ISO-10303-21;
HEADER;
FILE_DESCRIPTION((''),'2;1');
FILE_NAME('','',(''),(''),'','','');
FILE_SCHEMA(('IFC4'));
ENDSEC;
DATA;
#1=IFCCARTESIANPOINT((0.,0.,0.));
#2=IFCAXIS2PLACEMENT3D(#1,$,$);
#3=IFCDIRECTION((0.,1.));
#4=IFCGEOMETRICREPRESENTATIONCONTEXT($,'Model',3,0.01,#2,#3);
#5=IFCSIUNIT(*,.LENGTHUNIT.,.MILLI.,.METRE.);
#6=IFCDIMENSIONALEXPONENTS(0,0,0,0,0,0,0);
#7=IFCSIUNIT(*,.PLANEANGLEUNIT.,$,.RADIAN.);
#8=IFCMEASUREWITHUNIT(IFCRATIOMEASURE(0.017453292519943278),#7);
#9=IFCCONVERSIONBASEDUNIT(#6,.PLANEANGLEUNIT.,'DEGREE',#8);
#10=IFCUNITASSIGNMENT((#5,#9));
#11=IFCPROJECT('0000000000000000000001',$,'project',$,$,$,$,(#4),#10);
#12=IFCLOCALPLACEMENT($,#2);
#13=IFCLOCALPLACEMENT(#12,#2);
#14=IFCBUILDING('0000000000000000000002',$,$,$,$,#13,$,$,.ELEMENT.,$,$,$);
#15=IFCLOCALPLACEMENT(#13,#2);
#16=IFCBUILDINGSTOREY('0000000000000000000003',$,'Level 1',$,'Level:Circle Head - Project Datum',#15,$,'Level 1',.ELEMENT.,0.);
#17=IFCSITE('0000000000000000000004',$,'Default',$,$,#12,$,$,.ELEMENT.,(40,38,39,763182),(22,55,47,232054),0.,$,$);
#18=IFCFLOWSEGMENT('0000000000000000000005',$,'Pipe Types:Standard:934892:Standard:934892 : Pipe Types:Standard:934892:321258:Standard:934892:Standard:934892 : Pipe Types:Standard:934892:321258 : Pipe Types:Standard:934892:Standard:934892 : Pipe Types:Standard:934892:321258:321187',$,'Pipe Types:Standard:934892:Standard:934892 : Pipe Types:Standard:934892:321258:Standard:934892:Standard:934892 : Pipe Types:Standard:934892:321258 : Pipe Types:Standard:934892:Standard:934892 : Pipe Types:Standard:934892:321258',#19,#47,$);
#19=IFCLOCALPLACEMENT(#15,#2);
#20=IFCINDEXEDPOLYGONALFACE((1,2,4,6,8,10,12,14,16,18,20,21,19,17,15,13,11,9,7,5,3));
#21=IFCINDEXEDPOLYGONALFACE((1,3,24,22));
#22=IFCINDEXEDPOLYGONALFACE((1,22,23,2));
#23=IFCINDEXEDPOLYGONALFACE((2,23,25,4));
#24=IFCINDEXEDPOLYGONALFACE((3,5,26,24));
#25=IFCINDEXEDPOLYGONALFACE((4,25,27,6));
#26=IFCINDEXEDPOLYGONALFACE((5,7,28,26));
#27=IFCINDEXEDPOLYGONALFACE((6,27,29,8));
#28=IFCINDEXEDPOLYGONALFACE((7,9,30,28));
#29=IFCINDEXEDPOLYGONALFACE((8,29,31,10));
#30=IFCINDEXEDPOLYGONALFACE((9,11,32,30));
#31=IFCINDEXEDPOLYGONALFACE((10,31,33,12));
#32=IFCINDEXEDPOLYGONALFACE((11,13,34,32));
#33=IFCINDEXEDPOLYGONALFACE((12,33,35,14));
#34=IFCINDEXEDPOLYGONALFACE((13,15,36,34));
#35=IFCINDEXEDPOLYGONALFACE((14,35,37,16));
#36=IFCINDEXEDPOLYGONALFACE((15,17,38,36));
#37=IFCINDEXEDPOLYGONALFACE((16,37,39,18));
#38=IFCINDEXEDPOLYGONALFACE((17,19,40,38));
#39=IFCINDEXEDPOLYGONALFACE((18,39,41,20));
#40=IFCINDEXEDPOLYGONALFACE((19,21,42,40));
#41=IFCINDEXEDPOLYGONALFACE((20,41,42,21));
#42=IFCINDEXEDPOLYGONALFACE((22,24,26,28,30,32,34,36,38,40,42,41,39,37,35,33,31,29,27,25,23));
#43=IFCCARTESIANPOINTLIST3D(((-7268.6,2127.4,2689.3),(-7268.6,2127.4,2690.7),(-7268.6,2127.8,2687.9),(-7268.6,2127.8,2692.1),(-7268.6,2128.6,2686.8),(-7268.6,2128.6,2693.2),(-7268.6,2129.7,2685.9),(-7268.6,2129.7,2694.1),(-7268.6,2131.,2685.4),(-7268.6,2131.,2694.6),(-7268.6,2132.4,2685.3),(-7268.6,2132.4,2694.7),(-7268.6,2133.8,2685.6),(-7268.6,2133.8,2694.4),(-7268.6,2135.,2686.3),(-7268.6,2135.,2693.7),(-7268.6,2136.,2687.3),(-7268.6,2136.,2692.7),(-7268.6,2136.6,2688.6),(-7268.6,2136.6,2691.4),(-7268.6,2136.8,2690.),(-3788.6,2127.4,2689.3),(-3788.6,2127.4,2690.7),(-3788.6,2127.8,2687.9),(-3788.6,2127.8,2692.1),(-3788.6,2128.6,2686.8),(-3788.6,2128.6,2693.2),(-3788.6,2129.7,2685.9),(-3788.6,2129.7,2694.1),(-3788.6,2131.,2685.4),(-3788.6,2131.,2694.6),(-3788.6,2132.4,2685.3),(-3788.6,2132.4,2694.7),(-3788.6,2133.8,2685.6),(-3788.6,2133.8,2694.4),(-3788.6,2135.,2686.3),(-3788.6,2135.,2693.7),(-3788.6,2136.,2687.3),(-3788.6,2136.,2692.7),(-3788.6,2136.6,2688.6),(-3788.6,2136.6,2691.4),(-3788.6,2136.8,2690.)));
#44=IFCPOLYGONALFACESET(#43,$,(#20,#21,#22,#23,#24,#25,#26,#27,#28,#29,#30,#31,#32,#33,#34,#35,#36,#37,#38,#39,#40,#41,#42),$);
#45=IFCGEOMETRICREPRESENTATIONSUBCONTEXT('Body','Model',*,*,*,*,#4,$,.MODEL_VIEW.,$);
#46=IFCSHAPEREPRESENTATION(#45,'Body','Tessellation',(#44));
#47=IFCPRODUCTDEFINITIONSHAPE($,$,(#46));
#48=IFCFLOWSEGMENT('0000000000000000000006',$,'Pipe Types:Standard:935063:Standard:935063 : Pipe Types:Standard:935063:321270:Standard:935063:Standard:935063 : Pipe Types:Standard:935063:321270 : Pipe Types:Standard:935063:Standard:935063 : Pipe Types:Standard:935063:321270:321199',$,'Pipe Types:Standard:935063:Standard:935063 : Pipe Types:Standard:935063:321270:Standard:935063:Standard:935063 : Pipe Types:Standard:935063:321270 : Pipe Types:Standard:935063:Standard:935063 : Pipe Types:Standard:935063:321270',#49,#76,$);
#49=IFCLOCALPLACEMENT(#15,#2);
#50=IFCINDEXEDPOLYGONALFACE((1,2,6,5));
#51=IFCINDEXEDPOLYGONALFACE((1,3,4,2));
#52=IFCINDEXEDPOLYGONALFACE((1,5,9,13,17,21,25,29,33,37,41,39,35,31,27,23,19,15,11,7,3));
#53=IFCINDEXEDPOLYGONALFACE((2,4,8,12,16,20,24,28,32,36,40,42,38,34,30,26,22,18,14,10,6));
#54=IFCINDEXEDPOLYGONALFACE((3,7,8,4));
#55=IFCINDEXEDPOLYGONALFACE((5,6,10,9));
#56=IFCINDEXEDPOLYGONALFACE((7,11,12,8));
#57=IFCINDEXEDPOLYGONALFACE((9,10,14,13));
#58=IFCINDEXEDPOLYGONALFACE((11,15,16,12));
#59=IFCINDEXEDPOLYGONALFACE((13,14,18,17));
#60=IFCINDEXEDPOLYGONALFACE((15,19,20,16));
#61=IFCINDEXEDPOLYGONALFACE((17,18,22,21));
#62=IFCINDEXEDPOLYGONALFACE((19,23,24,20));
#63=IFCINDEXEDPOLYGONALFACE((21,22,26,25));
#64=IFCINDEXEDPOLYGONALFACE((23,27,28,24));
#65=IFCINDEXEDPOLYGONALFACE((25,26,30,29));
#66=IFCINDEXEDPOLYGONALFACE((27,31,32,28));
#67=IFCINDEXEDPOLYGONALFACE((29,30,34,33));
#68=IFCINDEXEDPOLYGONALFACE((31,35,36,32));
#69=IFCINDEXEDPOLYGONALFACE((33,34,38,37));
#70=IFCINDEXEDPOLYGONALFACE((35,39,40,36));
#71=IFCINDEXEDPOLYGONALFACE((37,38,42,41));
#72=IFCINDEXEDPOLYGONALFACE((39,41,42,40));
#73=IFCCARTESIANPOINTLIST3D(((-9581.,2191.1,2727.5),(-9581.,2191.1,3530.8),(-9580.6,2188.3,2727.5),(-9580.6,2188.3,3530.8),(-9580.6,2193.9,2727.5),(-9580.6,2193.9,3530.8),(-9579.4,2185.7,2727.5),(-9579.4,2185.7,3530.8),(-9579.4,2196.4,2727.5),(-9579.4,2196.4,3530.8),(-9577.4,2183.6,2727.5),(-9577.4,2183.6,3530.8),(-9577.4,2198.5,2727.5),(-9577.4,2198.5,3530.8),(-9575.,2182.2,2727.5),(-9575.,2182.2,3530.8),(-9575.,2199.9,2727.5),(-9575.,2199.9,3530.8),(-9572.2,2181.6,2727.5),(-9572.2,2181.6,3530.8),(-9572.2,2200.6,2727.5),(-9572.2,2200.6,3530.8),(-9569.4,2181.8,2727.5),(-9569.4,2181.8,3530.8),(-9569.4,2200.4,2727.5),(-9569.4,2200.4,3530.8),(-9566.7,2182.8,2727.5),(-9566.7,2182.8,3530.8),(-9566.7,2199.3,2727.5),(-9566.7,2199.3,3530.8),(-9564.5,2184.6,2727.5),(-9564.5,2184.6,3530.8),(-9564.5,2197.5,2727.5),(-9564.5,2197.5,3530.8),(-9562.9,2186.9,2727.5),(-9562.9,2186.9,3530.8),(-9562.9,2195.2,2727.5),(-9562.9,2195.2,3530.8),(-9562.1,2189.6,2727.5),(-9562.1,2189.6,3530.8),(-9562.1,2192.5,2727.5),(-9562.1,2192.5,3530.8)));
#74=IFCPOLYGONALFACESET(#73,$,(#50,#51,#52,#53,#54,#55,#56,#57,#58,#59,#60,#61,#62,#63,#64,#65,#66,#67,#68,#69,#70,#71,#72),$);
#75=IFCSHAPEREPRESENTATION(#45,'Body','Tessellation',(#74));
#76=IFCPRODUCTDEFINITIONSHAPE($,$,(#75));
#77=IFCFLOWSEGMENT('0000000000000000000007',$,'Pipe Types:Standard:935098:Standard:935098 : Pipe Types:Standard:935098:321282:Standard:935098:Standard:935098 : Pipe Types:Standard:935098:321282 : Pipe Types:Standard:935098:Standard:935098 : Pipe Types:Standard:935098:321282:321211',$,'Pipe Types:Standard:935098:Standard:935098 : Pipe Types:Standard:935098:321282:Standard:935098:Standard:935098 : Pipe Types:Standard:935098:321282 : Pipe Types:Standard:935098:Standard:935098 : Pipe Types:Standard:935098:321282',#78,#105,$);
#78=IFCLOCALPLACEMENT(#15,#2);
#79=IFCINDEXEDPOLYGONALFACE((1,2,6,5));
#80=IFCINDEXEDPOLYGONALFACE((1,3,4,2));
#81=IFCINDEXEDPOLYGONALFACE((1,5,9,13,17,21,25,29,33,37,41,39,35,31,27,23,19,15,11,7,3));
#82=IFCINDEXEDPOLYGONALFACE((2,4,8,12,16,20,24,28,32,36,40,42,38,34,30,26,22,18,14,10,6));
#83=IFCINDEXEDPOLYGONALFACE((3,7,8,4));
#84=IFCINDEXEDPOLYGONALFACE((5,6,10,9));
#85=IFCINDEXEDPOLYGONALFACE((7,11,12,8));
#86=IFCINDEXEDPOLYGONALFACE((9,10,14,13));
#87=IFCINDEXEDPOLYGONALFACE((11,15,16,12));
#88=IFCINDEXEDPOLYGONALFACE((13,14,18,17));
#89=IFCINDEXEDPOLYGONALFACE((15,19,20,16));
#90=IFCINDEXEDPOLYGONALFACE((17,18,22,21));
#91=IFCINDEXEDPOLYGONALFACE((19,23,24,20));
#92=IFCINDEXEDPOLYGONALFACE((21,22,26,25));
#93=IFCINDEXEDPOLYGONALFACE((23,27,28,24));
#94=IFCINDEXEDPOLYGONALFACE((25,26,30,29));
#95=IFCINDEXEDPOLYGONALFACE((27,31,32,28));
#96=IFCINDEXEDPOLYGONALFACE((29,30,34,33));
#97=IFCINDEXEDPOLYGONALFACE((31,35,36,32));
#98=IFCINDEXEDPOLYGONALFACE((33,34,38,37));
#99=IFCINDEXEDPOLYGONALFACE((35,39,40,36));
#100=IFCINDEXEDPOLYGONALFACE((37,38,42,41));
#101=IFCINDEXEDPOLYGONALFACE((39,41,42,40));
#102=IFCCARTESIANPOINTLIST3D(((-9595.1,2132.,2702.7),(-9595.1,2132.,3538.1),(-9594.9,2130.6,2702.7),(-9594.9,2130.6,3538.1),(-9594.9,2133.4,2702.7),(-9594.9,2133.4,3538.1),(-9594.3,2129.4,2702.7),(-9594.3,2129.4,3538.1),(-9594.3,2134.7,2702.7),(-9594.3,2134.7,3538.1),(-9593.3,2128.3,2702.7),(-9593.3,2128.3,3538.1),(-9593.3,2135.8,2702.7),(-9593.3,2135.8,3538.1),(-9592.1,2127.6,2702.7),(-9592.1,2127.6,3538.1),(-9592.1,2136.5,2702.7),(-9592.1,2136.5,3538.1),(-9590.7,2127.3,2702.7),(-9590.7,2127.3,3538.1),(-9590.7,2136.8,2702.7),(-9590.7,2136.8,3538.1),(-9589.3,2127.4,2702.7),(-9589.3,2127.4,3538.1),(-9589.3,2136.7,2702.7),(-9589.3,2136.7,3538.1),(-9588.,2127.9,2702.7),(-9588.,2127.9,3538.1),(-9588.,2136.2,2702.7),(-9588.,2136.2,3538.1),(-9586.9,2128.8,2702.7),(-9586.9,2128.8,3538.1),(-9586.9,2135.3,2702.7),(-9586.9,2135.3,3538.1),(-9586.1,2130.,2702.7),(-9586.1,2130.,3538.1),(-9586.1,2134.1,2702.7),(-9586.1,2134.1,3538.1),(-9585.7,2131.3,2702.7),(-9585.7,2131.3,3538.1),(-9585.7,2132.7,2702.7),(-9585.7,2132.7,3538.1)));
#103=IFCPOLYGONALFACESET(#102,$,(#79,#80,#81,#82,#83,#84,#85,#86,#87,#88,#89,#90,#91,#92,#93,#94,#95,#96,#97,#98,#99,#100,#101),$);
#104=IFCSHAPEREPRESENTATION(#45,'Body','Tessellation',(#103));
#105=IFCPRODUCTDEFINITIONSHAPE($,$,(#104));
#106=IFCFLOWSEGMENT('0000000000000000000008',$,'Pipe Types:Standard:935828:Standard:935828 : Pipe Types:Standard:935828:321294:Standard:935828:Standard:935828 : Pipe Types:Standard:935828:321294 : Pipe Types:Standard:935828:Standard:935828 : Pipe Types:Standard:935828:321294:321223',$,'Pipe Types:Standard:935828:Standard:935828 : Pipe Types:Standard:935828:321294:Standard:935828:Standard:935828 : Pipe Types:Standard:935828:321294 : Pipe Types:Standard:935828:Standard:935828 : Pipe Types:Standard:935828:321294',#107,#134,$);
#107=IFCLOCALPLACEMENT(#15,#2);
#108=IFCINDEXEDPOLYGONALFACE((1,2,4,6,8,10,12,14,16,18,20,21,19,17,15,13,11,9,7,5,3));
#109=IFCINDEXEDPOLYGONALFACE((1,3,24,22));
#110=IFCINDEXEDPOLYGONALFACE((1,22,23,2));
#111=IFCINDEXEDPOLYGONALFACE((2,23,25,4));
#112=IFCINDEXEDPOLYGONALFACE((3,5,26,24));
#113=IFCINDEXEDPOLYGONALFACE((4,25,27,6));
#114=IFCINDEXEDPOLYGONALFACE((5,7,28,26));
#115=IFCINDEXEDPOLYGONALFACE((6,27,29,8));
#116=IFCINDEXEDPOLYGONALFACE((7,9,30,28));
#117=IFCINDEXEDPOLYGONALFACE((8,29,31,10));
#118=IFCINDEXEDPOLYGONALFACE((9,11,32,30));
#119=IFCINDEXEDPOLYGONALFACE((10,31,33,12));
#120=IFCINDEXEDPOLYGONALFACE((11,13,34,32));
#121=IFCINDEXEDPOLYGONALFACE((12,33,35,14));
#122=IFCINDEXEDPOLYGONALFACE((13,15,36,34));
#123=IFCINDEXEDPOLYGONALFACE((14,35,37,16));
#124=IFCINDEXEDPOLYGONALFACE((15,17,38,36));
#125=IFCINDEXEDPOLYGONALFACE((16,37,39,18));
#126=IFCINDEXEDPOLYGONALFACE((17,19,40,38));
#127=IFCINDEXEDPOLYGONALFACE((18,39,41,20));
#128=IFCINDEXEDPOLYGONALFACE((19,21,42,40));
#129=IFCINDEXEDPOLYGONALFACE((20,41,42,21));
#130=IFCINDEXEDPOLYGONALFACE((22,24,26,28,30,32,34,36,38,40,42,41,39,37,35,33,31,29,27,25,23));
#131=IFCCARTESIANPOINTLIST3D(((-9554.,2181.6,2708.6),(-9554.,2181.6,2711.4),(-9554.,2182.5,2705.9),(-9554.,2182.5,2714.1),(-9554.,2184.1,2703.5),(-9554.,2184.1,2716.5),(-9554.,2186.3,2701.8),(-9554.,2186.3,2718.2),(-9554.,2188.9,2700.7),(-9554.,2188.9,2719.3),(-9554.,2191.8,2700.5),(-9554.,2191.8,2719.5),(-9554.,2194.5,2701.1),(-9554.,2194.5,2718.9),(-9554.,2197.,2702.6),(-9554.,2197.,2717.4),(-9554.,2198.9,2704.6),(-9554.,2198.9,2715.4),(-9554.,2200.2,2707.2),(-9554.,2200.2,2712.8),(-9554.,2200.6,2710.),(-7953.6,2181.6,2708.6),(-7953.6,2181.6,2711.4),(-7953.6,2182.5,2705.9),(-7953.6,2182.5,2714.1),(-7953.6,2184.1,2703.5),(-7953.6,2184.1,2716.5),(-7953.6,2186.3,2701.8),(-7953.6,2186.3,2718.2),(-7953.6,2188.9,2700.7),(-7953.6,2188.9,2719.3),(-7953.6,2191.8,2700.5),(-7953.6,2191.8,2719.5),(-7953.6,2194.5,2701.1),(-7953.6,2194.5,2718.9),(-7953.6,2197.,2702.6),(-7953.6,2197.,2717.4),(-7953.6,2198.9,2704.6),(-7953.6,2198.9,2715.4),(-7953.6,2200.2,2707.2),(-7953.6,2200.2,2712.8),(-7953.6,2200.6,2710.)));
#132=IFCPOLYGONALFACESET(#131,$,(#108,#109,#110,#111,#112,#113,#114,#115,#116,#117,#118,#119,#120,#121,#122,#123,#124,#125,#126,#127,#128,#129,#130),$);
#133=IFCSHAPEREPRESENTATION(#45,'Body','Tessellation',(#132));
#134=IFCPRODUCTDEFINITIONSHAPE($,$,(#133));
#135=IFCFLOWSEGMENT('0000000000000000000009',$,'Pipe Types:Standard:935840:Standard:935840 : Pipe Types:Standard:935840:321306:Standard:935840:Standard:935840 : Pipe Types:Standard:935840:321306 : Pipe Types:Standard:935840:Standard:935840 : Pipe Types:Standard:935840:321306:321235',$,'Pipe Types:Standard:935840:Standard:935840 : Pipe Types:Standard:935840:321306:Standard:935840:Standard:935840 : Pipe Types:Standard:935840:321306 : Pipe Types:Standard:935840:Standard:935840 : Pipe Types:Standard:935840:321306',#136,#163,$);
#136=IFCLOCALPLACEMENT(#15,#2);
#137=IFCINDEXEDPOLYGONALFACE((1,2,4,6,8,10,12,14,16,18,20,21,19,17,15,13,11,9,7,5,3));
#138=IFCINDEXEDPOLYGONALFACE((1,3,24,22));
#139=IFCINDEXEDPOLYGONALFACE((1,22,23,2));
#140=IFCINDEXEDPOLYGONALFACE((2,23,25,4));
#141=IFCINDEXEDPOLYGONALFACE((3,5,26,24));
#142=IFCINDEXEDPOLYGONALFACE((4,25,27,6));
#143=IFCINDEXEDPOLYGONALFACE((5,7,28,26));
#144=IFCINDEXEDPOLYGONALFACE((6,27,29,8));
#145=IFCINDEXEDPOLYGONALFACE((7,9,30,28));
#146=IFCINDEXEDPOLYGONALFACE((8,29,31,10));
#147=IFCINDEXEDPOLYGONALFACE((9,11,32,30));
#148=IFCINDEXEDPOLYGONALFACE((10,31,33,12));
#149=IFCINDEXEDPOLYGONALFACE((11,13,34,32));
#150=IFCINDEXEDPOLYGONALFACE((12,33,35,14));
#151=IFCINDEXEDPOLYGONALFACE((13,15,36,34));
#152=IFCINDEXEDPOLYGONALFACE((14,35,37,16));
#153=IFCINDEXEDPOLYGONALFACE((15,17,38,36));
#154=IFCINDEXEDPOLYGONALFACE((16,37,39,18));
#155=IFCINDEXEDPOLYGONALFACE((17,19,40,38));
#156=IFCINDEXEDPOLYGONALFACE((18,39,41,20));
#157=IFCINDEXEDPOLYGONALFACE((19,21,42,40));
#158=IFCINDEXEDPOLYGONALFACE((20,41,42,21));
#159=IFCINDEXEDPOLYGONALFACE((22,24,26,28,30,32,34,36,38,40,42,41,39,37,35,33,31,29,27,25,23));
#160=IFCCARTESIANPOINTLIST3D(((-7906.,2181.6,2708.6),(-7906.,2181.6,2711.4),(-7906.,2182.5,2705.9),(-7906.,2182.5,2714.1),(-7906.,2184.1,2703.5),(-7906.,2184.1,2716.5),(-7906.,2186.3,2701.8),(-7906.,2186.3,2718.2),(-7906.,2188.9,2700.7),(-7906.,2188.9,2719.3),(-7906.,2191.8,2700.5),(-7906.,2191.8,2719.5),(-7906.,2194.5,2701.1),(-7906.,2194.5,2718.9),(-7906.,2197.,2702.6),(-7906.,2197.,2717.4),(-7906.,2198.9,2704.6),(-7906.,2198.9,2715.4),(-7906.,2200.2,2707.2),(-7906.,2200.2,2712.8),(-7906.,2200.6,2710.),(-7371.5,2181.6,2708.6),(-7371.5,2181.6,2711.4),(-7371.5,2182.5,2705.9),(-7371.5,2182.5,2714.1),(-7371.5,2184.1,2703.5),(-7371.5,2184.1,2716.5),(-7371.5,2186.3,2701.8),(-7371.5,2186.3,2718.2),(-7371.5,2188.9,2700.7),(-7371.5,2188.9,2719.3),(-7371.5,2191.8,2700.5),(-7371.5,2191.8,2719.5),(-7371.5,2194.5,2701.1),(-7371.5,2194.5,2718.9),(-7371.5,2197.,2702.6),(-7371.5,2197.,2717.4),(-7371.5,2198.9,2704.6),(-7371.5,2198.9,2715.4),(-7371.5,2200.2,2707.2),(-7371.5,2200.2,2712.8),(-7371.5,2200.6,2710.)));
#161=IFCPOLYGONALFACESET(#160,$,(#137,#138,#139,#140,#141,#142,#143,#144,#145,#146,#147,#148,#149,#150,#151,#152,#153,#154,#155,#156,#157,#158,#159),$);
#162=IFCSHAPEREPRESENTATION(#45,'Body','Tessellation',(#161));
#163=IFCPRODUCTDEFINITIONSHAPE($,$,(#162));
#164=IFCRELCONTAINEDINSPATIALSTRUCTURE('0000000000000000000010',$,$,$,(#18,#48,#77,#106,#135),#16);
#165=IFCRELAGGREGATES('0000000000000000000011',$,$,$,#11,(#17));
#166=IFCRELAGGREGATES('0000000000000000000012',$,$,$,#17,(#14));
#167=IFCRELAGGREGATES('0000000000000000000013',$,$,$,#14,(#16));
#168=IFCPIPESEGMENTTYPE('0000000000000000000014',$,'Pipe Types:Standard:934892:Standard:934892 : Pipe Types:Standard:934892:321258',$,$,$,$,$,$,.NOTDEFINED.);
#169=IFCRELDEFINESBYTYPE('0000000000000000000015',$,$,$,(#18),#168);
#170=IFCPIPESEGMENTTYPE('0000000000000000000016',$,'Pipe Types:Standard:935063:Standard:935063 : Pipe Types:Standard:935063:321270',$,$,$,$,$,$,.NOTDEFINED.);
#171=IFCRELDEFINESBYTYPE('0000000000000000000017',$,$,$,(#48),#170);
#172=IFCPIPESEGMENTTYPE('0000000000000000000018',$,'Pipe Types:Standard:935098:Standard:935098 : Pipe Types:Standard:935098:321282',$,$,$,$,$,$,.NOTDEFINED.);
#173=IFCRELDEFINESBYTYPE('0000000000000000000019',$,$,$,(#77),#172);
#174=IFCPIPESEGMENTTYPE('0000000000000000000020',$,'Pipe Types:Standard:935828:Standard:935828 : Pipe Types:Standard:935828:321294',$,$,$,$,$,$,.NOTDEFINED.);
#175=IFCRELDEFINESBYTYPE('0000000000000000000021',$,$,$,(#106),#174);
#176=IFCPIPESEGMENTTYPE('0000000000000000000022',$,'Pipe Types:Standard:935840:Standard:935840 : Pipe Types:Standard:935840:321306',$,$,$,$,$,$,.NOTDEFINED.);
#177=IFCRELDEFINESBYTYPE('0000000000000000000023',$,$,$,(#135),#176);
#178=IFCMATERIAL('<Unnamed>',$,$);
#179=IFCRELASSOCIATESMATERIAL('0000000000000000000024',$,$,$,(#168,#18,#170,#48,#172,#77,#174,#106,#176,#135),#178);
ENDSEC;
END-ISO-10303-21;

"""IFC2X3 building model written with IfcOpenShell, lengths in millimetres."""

from ifc_helpers import new_model, entity, si_unit, converted_unit, direction, frame, origin, origin_2d_with_axis, place, context, subcontext, project, spatial, circle, extrude, source, transform, mapped, material, type_object, type_shapes, element, save


model = new_model("IFC2X3")

# Units and contexts
model_context = context("Model", 3, precision=0.01, world=origin(), true_north=direction((0.0, 1.0)))
body_context = subcontext(model_context, "Body", "Model", "MODEL_VIEW")
ifc_project = project(units=[si_unit("LENGTHUNIT", "METRE", prefix="MILLI"), converted_unit("PLANEANGLEUNIT", "DEGREE", entity("IfcRatioMeasure", 0.017453292519943278), si_unit("PLANEANGLEUNIT", "RADIAN"), dimensions=[0, 0, 0, 0, 0, 0, 0])], contexts=[model_context])

# Site, building, storey
site_placement = place(None, origin())
site = spatial("IfcSite", under=ifc_project, at=site_placement, Name="Default", CompositionType="ELEMENT", RefLatitude=(40, 38, 39, 763182), RefLongitude=(22, 55, 47, 232054), RefElevation=0.0)
building_placement = place(site_placement, origin())
building = spatial("IfcBuilding", under=site, at=building_placement, CompositionType="ELEMENT")
storey_placement = place(building_placement, origin())
storey = spatial("IfcBuildingStorey", under=building, at=storey_placement, Name="Level 1", ObjectType="Level:Circle Head - Project Datum", LongName="Level 1", CompositionType="ELEMENT", Elevation=0.0)

# Flow segments
ifc_material_1 = material(Name="<Unnamed>")
pipe_segment_type_1 = type_object("IfcPipeSegmentType", Name="Pipe Types:Standard:934892:Standard:934892 : Pipe Types:Standard:934892:321258", PredefinedType="NOTDEFINED", material=ifc_material_1)
shared_shape_1 = source(origin(), body_context, "Body", "SweptSolid", [
    extrude(circle(Radius=4.8, at=origin_2d_with_axis()), frame((-7268.6, 2132.1, 2690.0), z_axis=(1.0, 0.0, 0.0), x_axis=(0.0, 1.0, 0.0)), (0.0, 0.0, 1.0), 3480.0),
])
type_shapes(pipe_segment_type_1, [shared_shape_1])
flow_segment_1_placement = place(storey_placement, origin())
element("IfcFlowSegment", 1, at=flow_segment_1_placement, inside=storey, type_object=pipe_segment_type_1, material=ifc_material_1, Name="Pipe Types:Standard:934892:Standard:934892 : Pipe Types:Standard:934892:321258:Standard:934892:Standard:934892 : Pipe Types:Standard:934892:321258 : Pipe Types:Standard:934892:Standard:934892 : Pipe Types:Standard:934892:321258:321187", ObjectType="Pipe Types:Standard:934892:Standard:934892 : Pipe Types:Standard:934892:321258:Standard:934892:Standard:934892 : Pipe Types:Standard:934892:321258 : Pipe Types:Standard:934892:Standard:934892 : Pipe Types:Standard:934892:321258", context=body_context, shape_type="MappedRepresentation", body=[
    mapped(shared_shape_1, transform((0.0, 0.0, 0.0), scale=1.0)),
])
pipe_segment_type_2 = type_object("IfcPipeSegmentType", Name="Pipe Types:Standard:935063:Standard:935063 : Pipe Types:Standard:935063:321270", PredefinedType="NOTDEFINED", material=ifc_material_1)
shared_shape_2 = source(origin(), body_context, "Body", "SweptSolid", [
    extrude(circle(Radius=9.5, at=origin_2d_with_axis()), frame((-9571.5, 2191.1, 2727.5), z_axis=(0.0, 0.0, 1.0), x_axis=(-1.0, 0.0, 0.0)), (0.0, 0.0, 1.0), 803.3),
])
type_shapes(pipe_segment_type_2, [shared_shape_2])
flow_segment_2_placement = place(storey_placement, origin())
element("IfcFlowSegment", 2, at=flow_segment_2_placement, inside=storey, type_object=pipe_segment_type_2, material=ifc_material_1, Name="Pipe Types:Standard:935063:Standard:935063 : Pipe Types:Standard:935063:321270:Standard:935063:Standard:935063 : Pipe Types:Standard:935063:321270 : Pipe Types:Standard:935063:Standard:935063 : Pipe Types:Standard:935063:321270:321199", ObjectType="Pipe Types:Standard:935063:Standard:935063 : Pipe Types:Standard:935063:321270:Standard:935063:Standard:935063 : Pipe Types:Standard:935063:321270 : Pipe Types:Standard:935063:Standard:935063 : Pipe Types:Standard:935063:321270", context=body_context, shape_type="MappedRepresentation", body=[
    mapped(shared_shape_2, transform((0.0, 0.0, 0.0), scale=1.0)),
])
pipe_segment_type_3 = type_object("IfcPipeSegmentType", Name="Pipe Types:Standard:935098:Standard:935098 : Pipe Types:Standard:935098:321282", PredefinedType="NOTDEFINED", material=ifc_material_1)
shared_shape_3 = source(origin(), body_context, "Body", "SweptSolid", [
    extrude(circle(Radius=4.8, at=origin_2d_with_axis()), frame((-9590.4, 2132.0, 2702.7), z_axis=(0.0, 0.0, 1.0), x_axis=(-1.0, 0.0, 0.0)), (0.0, 0.0, 1.0), 835.4),
])
type_shapes(pipe_segment_type_3, [shared_shape_3])
flow_segment_3_placement = place(storey_placement, origin())
element("IfcFlowSegment", 3, at=flow_segment_3_placement, inside=storey, type_object=pipe_segment_type_3, material=ifc_material_1, Name="Pipe Types:Standard:935098:Standard:935098 : Pipe Types:Standard:935098:321282:Standard:935098:Standard:935098 : Pipe Types:Standard:935098:321282 : Pipe Types:Standard:935098:Standard:935098 : Pipe Types:Standard:935098:321282:321211", ObjectType="Pipe Types:Standard:935098:Standard:935098 : Pipe Types:Standard:935098:321282:Standard:935098:Standard:935098 : Pipe Types:Standard:935098:321282 : Pipe Types:Standard:935098:Standard:935098 : Pipe Types:Standard:935098:321282", context=body_context, shape_type="MappedRepresentation", body=[
    mapped(shared_shape_3, transform((0.0, 0.0, 0.0), scale=1.0)),
])
pipe_segment_type_4 = type_object("IfcPipeSegmentType", Name="Pipe Types:Standard:935828:Standard:935828 : Pipe Types:Standard:935828:321294", PredefinedType="NOTDEFINED", material=ifc_material_1)
shared_shape_4 = source(origin(), body_context, "Body", "SweptSolid", [
    extrude(circle(Radius=9.5, at=origin_2d_with_axis()), frame((-9554.0, 2191.1, 2710.0), z_axis=(1.0, 0.0, 0.0), x_axis=(0.0, 1.0, 0.0)), (0.0, 0.0, 1.0), 1600.4),
])
type_shapes(pipe_segment_type_4, [shared_shape_4])
flow_segment_4_placement = place(storey_placement, origin())
element("IfcFlowSegment", 4, at=flow_segment_4_placement, inside=storey, type_object=pipe_segment_type_4, material=ifc_material_1, Name="Pipe Types:Standard:935828:Standard:935828 : Pipe Types:Standard:935828:321294:Standard:935828:Standard:935828 : Pipe Types:Standard:935828:321294 : Pipe Types:Standard:935828:Standard:935828 : Pipe Types:Standard:935828:321294:321223", ObjectType="Pipe Types:Standard:935828:Standard:935828 : Pipe Types:Standard:935828:321294:Standard:935828:Standard:935828 : Pipe Types:Standard:935828:321294 : Pipe Types:Standard:935828:Standard:935828 : Pipe Types:Standard:935828:321294", context=body_context, shape_type="MappedRepresentation", body=[
    mapped(shared_shape_4, transform((0.0, 0.0, 0.0), scale=1.0)),
])
pipe_segment_type_5 = type_object("IfcPipeSegmentType", Name="Pipe Types:Standard:935840:Standard:935840 : Pipe Types:Standard:935840:321306", PredefinedType="NOTDEFINED", material=ifc_material_1)
shared_shape_5 = source(origin(), body_context, "Body", "SweptSolid", [
    extrude(circle(Radius=9.5, at=origin_2d_with_axis()), frame((-7906.0, 2191.1, 2710.0), z_axis=(1.0, 0.0, 0.0), x_axis=(0.0, 1.0, 0.0)), (0.0, 0.0, 1.0), 534.5),
])
type_shapes(pipe_segment_type_5, [shared_shape_5])
flow_segment_5_placement = place(storey_placement, origin())
element("IfcFlowSegment", 5, at=flow_segment_5_placement, inside=storey, type_object=pipe_segment_type_5, material=ifc_material_1, Name="Pipe Types:Standard:935840:Standard:935840 : Pipe Types:Standard:935840:321306:Standard:935840:Standard:935840 : Pipe Types:Standard:935840:321306 : Pipe Types:Standard:935840:Standard:935840 : Pipe Types:Standard:935840:321306:321235", ObjectType="Pipe Types:Standard:935840:Standard:935840 : Pipe Types:Standard:935840:321306:Standard:935840:Standard:935840 : Pipe Types:Standard:935840:321306 : Pipe Types:Standard:935840:Standard:935840 : Pipe Types:Standard:935840:321306", context=body_context, shape_type="MappedRepresentation", body=[
    mapped(shared_shape_5, transform((0.0, 0.0, 0.0), scale=1.0)),
])

save(model, "model.ifc")
